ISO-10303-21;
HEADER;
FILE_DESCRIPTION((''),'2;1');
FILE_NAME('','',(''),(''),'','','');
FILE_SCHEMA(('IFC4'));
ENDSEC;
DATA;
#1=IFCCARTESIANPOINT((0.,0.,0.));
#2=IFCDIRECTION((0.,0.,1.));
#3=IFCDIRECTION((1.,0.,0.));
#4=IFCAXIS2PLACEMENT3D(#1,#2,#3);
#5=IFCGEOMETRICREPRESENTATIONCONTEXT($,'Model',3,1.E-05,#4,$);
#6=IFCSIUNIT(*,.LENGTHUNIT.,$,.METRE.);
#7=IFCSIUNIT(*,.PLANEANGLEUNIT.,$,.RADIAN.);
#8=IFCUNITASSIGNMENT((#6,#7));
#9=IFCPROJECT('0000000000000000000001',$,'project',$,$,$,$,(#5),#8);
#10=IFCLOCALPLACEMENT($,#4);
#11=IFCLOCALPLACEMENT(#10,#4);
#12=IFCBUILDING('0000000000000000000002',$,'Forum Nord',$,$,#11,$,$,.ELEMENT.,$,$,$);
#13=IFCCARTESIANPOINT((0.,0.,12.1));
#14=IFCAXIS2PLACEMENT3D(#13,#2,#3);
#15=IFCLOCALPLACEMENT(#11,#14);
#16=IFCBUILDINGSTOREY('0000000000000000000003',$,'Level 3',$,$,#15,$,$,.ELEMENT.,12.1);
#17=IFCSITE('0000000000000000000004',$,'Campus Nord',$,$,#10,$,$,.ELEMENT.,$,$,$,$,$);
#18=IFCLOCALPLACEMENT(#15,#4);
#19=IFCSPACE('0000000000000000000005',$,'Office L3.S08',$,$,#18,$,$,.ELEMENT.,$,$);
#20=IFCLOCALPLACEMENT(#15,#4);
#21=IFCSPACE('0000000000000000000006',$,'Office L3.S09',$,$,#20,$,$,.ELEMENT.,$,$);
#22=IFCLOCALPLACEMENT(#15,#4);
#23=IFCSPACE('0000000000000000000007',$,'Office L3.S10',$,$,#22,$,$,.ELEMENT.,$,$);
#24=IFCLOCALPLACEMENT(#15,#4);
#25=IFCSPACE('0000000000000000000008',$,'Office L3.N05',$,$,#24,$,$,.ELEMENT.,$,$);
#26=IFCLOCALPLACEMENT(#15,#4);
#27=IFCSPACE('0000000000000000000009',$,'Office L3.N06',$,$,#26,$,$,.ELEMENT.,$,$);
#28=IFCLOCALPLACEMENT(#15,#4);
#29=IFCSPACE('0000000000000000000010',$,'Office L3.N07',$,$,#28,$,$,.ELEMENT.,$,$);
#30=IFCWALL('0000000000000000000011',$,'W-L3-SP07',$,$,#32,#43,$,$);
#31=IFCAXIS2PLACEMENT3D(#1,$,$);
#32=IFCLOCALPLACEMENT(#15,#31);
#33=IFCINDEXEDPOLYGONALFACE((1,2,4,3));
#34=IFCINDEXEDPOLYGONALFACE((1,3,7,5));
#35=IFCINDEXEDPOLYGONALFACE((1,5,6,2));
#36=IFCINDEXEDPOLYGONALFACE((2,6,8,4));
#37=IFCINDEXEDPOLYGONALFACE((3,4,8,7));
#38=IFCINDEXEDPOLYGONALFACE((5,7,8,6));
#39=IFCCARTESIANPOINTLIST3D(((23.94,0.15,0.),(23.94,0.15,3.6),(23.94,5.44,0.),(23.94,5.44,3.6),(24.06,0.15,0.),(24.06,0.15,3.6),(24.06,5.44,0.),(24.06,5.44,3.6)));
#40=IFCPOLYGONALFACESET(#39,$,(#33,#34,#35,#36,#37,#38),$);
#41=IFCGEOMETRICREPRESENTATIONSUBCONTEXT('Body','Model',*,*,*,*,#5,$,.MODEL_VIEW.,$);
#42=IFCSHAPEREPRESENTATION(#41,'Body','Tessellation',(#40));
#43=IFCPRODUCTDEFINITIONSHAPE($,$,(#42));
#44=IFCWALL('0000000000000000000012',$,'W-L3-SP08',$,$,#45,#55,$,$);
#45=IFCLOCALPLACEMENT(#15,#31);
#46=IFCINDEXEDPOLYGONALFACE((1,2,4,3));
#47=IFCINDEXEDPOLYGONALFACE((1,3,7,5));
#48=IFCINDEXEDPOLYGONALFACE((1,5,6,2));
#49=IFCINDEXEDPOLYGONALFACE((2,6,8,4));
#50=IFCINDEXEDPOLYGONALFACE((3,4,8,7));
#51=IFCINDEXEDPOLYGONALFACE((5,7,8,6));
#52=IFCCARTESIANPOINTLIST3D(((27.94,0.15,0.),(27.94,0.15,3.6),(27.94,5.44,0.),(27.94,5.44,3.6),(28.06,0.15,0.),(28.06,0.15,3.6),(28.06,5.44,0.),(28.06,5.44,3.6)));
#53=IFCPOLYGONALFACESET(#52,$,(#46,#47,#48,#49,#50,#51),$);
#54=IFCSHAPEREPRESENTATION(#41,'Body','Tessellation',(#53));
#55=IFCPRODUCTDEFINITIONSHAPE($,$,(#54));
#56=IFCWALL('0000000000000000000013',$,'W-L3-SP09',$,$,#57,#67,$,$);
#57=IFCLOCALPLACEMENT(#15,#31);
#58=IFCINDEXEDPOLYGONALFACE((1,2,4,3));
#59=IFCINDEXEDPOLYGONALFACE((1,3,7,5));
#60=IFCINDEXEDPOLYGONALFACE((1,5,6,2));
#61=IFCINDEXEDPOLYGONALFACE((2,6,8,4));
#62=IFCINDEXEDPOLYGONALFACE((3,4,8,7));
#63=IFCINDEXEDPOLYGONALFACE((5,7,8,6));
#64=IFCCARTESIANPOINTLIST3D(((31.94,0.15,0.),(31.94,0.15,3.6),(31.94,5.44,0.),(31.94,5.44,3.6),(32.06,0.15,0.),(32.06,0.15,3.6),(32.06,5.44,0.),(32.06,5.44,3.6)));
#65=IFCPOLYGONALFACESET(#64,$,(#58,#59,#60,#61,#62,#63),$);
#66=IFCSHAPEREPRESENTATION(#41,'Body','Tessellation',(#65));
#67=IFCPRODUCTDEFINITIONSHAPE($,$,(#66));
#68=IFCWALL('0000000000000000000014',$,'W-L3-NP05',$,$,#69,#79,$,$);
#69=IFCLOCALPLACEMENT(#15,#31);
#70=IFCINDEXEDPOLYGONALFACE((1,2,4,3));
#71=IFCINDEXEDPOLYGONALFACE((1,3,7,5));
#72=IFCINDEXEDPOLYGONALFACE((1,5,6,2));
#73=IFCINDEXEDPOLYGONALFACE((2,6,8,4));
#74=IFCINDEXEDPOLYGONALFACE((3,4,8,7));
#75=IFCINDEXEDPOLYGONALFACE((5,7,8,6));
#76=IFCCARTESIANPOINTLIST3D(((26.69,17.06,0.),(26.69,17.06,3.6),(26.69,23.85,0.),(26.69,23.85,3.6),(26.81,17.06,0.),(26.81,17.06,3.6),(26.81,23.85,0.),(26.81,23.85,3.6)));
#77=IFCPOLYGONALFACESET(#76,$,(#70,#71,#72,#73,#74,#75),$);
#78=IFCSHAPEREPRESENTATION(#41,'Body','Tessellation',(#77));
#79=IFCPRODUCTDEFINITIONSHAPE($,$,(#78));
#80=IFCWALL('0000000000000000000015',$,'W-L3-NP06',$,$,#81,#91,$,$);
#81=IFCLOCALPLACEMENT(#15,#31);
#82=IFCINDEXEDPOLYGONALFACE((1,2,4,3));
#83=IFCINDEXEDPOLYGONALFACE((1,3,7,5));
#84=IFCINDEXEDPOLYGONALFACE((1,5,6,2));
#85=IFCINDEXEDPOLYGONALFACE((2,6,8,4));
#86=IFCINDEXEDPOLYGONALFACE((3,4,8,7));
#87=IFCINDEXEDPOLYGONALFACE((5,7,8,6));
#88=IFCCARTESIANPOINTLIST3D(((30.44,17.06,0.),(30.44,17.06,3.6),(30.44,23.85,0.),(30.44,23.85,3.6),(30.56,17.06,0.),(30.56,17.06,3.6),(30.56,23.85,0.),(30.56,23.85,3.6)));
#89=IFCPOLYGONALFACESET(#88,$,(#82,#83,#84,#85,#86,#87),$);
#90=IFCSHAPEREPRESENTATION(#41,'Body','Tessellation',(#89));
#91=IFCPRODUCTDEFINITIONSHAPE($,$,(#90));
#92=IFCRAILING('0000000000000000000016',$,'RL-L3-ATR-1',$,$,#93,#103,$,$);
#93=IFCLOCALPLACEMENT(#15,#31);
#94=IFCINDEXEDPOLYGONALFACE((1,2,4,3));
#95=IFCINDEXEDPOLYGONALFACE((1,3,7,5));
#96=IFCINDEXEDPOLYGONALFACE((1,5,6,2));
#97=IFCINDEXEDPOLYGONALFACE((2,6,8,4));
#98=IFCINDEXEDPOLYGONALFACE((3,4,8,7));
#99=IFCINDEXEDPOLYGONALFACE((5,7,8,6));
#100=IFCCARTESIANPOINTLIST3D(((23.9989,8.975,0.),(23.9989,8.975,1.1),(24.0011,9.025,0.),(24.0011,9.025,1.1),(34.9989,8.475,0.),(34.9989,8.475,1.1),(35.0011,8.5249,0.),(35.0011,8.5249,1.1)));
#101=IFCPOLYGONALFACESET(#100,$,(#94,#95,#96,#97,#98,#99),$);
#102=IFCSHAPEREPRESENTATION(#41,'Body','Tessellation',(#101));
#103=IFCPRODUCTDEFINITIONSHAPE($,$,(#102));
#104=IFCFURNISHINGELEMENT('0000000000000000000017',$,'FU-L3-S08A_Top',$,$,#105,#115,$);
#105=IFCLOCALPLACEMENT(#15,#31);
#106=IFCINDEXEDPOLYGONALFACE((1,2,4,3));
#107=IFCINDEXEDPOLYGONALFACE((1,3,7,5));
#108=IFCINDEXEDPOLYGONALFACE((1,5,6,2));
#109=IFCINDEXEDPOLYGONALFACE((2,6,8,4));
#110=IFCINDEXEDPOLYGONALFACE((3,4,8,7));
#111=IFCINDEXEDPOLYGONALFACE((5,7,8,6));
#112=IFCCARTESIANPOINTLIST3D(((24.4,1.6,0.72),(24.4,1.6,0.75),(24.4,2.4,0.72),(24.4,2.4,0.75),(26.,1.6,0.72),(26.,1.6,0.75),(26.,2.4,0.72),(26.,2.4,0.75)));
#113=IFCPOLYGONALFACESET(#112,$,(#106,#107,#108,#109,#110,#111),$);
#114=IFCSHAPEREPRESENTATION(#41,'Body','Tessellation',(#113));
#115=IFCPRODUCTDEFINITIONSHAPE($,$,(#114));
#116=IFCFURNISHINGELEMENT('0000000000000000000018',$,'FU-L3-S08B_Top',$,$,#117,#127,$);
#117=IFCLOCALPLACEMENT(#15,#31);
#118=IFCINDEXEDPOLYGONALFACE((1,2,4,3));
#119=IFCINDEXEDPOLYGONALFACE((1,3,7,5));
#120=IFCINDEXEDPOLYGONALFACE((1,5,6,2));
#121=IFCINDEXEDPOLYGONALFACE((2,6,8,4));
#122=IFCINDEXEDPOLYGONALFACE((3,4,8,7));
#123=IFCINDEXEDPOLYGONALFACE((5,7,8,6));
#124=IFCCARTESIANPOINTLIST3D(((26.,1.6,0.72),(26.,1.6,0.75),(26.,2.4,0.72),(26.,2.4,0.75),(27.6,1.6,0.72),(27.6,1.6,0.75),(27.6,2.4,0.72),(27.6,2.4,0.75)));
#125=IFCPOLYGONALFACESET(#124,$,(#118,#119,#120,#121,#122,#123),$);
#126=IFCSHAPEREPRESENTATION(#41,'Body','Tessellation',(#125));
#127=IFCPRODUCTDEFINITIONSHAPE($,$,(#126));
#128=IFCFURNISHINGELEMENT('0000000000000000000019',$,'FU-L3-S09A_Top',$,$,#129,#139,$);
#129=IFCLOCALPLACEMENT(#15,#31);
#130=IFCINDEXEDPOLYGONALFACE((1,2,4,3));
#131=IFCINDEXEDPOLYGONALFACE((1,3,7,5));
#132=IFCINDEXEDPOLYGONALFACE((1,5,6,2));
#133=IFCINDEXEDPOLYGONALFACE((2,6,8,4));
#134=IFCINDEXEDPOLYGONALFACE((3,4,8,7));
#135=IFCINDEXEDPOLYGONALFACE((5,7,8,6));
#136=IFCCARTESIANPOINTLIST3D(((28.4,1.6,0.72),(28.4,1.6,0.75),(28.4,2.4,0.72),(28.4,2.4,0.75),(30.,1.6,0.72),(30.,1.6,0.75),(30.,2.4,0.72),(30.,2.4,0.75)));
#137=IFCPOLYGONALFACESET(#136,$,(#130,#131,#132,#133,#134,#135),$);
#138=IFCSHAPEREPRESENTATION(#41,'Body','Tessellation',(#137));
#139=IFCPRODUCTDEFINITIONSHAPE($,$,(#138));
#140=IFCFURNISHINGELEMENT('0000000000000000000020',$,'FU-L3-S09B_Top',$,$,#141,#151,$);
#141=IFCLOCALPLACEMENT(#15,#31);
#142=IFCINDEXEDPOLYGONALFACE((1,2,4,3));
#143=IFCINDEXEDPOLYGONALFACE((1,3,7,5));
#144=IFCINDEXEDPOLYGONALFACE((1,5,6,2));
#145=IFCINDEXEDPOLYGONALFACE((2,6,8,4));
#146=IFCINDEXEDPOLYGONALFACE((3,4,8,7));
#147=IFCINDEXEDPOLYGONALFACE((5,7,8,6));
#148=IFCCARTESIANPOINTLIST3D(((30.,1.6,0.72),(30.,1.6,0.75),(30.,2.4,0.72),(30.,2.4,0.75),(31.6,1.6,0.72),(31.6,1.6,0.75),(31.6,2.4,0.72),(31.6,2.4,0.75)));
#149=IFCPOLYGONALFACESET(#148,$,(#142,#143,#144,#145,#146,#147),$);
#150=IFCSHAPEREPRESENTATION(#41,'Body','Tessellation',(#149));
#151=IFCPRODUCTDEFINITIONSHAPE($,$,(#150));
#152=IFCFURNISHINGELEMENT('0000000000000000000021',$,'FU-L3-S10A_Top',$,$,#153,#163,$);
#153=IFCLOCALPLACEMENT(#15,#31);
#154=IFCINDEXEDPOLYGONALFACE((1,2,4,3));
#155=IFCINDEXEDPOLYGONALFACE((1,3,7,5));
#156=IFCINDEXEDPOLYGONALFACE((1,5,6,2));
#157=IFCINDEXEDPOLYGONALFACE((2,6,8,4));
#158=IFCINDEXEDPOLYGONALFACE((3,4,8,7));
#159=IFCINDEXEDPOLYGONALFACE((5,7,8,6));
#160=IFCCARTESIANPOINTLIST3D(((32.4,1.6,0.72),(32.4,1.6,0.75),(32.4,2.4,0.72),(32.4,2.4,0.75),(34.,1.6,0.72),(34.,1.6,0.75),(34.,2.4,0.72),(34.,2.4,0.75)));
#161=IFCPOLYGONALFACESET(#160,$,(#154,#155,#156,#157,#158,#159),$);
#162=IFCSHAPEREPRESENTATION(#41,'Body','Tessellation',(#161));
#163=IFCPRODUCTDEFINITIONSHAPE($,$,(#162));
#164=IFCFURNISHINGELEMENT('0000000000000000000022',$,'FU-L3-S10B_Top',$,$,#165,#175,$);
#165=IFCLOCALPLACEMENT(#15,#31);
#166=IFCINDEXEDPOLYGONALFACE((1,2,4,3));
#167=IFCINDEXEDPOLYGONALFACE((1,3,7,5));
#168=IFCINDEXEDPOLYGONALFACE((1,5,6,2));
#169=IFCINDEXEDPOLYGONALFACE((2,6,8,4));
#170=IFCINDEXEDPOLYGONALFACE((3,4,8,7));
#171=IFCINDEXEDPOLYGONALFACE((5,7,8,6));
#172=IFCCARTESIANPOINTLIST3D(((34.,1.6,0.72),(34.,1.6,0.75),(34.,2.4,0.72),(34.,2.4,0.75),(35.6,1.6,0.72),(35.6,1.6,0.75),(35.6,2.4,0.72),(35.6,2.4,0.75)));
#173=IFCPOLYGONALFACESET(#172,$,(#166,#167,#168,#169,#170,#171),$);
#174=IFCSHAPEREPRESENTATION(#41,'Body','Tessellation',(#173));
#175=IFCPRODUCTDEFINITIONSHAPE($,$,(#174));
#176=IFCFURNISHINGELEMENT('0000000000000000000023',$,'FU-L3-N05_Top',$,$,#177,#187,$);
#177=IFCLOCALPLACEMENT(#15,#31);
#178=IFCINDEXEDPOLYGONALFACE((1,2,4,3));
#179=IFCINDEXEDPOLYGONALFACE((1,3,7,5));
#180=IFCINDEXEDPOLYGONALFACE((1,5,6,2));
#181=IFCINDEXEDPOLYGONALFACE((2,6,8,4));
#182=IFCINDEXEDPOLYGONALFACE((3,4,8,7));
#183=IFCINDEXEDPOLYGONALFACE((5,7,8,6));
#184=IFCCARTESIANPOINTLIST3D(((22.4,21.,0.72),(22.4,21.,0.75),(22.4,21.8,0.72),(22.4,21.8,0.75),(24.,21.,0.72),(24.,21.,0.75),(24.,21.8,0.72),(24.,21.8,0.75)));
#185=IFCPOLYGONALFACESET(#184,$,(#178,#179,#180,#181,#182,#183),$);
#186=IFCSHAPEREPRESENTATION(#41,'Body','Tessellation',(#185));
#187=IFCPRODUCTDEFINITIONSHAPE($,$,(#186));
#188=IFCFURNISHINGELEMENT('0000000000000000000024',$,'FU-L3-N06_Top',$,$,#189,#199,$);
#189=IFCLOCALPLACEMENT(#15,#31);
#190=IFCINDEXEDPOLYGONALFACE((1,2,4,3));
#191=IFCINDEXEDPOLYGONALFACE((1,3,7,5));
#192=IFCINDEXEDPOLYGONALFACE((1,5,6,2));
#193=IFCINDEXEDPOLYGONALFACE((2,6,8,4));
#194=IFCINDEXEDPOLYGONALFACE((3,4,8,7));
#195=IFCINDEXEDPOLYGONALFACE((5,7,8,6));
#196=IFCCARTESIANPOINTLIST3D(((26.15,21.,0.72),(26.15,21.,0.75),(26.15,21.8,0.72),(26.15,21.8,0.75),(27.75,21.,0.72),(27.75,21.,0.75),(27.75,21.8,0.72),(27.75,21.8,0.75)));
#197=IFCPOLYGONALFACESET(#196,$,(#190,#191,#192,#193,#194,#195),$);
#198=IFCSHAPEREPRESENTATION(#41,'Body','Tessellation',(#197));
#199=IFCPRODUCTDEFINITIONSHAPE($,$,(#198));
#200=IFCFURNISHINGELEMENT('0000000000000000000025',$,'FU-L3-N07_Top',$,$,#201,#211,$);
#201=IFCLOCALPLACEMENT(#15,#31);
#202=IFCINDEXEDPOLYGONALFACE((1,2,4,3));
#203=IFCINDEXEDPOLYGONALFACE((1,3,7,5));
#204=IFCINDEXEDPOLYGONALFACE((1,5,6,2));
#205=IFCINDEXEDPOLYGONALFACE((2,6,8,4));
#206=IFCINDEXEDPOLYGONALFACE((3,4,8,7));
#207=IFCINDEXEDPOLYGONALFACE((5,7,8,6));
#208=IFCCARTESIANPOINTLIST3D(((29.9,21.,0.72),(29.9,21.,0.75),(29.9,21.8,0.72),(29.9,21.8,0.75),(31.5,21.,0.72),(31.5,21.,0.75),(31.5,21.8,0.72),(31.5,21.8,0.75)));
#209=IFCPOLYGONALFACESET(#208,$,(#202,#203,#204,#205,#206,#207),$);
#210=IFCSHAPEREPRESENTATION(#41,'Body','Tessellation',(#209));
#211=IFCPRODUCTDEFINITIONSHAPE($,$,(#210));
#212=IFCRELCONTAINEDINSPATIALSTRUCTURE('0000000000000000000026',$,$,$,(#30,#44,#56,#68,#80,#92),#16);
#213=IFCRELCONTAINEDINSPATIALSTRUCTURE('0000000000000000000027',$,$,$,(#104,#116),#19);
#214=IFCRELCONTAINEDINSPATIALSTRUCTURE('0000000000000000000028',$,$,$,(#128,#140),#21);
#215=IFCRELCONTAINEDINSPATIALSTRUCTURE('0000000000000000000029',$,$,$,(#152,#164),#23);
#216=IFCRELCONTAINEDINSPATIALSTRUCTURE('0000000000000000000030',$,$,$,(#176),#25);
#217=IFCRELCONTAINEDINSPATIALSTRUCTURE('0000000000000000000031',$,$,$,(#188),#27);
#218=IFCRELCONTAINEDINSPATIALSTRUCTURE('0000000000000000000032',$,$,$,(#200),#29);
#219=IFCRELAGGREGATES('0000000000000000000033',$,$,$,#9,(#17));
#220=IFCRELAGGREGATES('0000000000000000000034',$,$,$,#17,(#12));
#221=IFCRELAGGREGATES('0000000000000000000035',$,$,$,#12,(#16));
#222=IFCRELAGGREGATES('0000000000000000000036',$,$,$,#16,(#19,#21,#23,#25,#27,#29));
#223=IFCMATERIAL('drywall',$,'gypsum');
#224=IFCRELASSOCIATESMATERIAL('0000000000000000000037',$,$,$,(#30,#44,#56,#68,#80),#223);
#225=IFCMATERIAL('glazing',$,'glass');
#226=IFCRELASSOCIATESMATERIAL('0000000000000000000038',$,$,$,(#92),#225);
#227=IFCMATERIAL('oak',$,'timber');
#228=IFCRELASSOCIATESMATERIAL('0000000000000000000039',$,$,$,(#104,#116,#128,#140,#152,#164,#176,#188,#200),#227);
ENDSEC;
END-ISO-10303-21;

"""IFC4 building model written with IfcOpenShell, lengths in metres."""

from ifc_helpers import new_model, si_unit, frame, frame_2d, origin_with_axes, place, context, subcontext, project, spatial, polyline, rectangle, outline, extrude, material, element, save


model = new_model("IFC4")

# Units and contexts
model_context = context("Model", 3, precision=1e-05, world=origin_with_axes())
body_context = subcontext(model_context, "Body", "Model", "MODEL_VIEW")
ifc_project = project(units=[si_unit("LENGTHUNIT", "METRE"), si_unit("PLANEANGLEUNIT", "RADIAN")], contexts=[model_context])

# Site, building, storey
site_placement = place(None, origin_with_axes())
site = spatial("IfcSite", under=ifc_project, at=site_placement, Name="Campus Nord", CompositionType="ELEMENT")
building_placement = place(site_placement, origin_with_axes())
building = spatial("IfcBuilding", under=site, at=building_placement, Name="Forum Nord", CompositionType="ELEMENT")
storey_placement = place(building_placement, frame((0.0, 0.0, 12.1), z_axis=(0.0, 0.0, 1.0), x_axis=(1.0, 0.0, 0.0)))
storey = spatial("IfcBuildingStorey", under=building, at=storey_placement, Name="Level 3", CompositionType="ELEMENT", Elevation=12.1)

# Walls
ifc_material_1 = material(Name="drywall", Category="gypsum")
for number, where, z_axis, x_axis, name in (
    (1, (24.0, 0.0, 0.0), (0.0, 0.0, 1.0), (0.0, 1.0, 0.0), "W-L3-SP07"),
    (2, (28.0, 0.0, 0.0), (0.0, 0.0, 1.0), (0.0, 1.0, 0.0), "W-L3-SP08"),
    (3, (32.0, 0.0, 0.0), (0.0, 0.0, 1.0), (0.0, 1.0, 0.0), "W-L3-SP09"),
):
    element("IfcWall", number, at=place(storey_placement, frame(where, z_axis=z_axis, x_axis=x_axis)), inside=storey, material=ifc_material_1, Name=name, context=body_context, shape_type="SweptSolid", body=[
        extrude(outline(polyline([(0.15, -0.06), (5.44, -0.06), (5.44, 0.06), (0.15, 0.06), (0.15, -0.06)])), origin_with_axes(), (0.0, 0.0, 1.0), 3.6),
    ])
for number, where, z_axis, x_axis, name in (
    (4, (26.75, 17.0, 0.0), (0.0, 0.0, 1.0), (0.0, 1.0, 0.0), "W-L3-NP05"),
    (5, (30.5, 17.0, 0.0), (0.0, 0.0, 1.0), (0.0, 1.0, 0.0), "W-L3-NP06"),
):
    element("IfcWall", number, at=place(storey_placement, frame(where, z_axis=z_axis, x_axis=x_axis)), inside=storey, material=ifc_material_1, Name=name, context=body_context, shape_type="SweptSolid", body=[
        extrude(outline(polyline([(0.06, -0.06), (6.85, -0.06), (6.85, 0.06), (0.06, 0.06), (0.06, -0.06)])), origin_with_axes(), (0.0, 0.0, 1.0), 3.6),
    ])

# Railing
ifc_material_2 = material(Name="glazing", Category="glass")
railing_placement = place(storey_placement, frame((24.0, 9.0, 0.0), z_axis=(0.0, 0.0, 1.0), x_axis=(0.99897, -0.04541, 0.0)))
element("IfcRailing", 6, at=railing_placement, inside=storey, material=ifc_material_2, Name="RL-L3-ATR-1", context=body_context, shape_type="SweptSolid", body=[
    extrude(rectangle(XDim=11.0114, YDim=0.05, at=frame_2d((5.5057, 0.0), x_axis=(1.0, 0.0))), origin_with_axes(), (0.0, 0.0, 1.0), 1.1),
])

# Shared definitions
space_1_placement = place(storey_placement, origin_with_axes())
space_1 = spatial("IfcSpace", under=storey, at=space_1_placement, Name="Office L3.S08", CompositionType="ELEMENT")

# Furnishing elements
ifc_material_3 = material(Name="oak", Category="timber")
furnishing_1_placement = place(storey_placement, frame((24.4, 1.0, 0.0), z_axis=(0.0, 0.0, 1.0), x_axis=(1.0, 0.0, 0.0)))
element("IfcFurnishingElement", 7, at=furnishing_1_placement, inside=space_1, material=ifc_material_3, Name="FU-L3-S08A_Top", context=body_context, shape_type="SweptSolid", body=[
    extrude(rectangle(XDim=1.6, YDim=0.8, at=frame_2d((0.8, 1.0), x_axis=(1.0, 0.0))), frame((0.0, 0.0, 0.72), z_axis=(0.0, 0.0, 1.0), x_axis=(1.0, 0.0, 0.0)), (0.0, 0.0, 1.0), 0.03),
])
furnishing_2_placement = place(storey_placement, frame((26.0, 1.0, 0.0), z_axis=(0.0, 0.0, 1.0), x_axis=(1.0, 0.0, 0.0)))
element("IfcFurnishingElement", 8, at=furnishing_2_placement, inside=space_1, material=ifc_material_3, Name="FU-L3-S08B_Top", context=body_context, shape_type="SweptSolid", body=[
    extrude(rectangle(XDim=1.6, YDim=0.8, at=frame_2d((0.8, 1.0), x_axis=(1.0, 0.0))), frame((0.0, 0.0, 0.72), z_axis=(0.0, 0.0, 1.0), x_axis=(1.0, 0.0, 0.0)), (0.0, 0.0, 1.0), 0.03),
])

# Shared definitions
space_2_placement = place(storey_placement, origin_with_axes())
space_2 = spatial("IfcSpace", under=storey, at=space_2_placement, Name="Office L3.S09", CompositionType="ELEMENT")

# Furnishing elements
furnishing_3_placement = place(storey_placement, frame((28.4, 1.0, 0.0), z_axis=(0.0, 0.0, 1.0), x_axis=(1.0, 0.0, 0.0)))
element("IfcFurnishingElement", 9, at=furnishing_3_placement, inside=space_2, material=ifc_material_3, Name="FU-L3-S09A_Top", context=body_context, shape_type="SweptSolid", body=[
    extrude(rectangle(XDim=1.6, YDim=0.8, at=frame_2d((0.8, 1.0), x_axis=(1.0, 0.0))), frame((0.0, 0.0, 0.72), z_axis=(0.0, 0.0, 1.0), x_axis=(1.0, 0.0, 0.0)), (0.0, 0.0, 1.0), 0.03),
])
furnishing_4_placement = place(storey_placement, frame((30.0, 1.0, 0.0), z_axis=(0.0, 0.0, 1.0), x_axis=(1.0, 0.0, 0.0)))
element("IfcFurnishingElement", 10, at=furnishing_4_placement, inside=space_2, material=ifc_material_3, Name="FU-L3-S09B_Top", context=body_context, shape_type="SweptSolid", body=[
    extrude(rectangle(XDim=1.6, YDim=0.8, at=frame_2d((0.8, 1.0), x_axis=(1.0, 0.0))), frame((0.0, 0.0, 0.72), z_axis=(0.0, 0.0, 1.0), x_axis=(1.0, 0.0, 0.0)), (0.0, 0.0, 1.0), 0.03),
])

# Shared definitions
space_3_placement = place(storey_placement, origin_with_axes())
space_3 = spatial("IfcSpace", under=storey, at=space_3_placement, Name="Office L3.S10", CompositionType="ELEMENT")

# Furnishing elements
furnishing_5_placement = place(storey_placement, frame((32.4, 1.0, 0.0), z_axis=(0.0, 0.0, 1.0), x_axis=(1.0, 0.0, 0.0)))
element("IfcFurnishingElement", 11, at=furnishing_5_placement, inside=space_3, material=ifc_material_3, Name="FU-L3-S10A_Top", context=body_context, shape_type="SweptSolid", body=[
    extrude(rectangle(XDim=1.6, YDim=0.8, at=frame_2d((0.8, 1.0), x_axis=(1.0, 0.0))), frame((0.0, 0.0, 0.72), z_axis=(0.0, 0.0, 1.0), x_axis=(1.0, 0.0, 0.0)), (0.0, 0.0, 1.0), 0.03),
])
furnishing_6_placement = place(storey_placement, frame((34.0, 1.0, 0.0), z_axis=(0.0, 0.0, 1.0), x_axis=(1.0, 0.0, 0.0)))
element("IfcFurnishingElement", 12, at=furnishing_6_placement, inside=space_3, material=ifc_material_3, Name="FU-L3-S10B_Top", context=body_context, shape_type="SweptSolid", body=[
    extrude(rectangle(XDim=1.6, YDim=0.8, at=frame_2d((0.8, 1.0), x_axis=(1.0, 0.0))), frame((0.0, 0.0, 0.72), z_axis=(0.0, 0.0, 1.0), x_axis=(1.0, 0.0, 0.0)), (0.0, 0.0, 1.0), 0.03),
])

# Shared definitions
space_4_placement = place(storey_placement, origin_with_axes())
space_4 = spatial("IfcSpace", under=storey, at=space_4_placement, Name="Office L3.N05", CompositionType="ELEMENT")

# Furnishing element
furnishing_7_placement = place(storey_placement, frame((24.0, 22.4, 0.0), z_axis=(0.0, 0.0, 1.0), x_axis=(-1.0, 0.0, 0.0)))
element("IfcFurnishingElement", 13, at=furnishing_7_placement, inside=space_4, material=ifc_material_3, Name="FU-L3-N05_Top", context=body_context, shape_type="SweptSolid", body=[
    extrude(rectangle(XDim=1.6, YDim=0.8, at=frame_2d((0.8, 1.0), x_axis=(1.0, 0.0))), frame((0.0, 0.0, 0.72), z_axis=(0.0, 0.0, 1.0), x_axis=(1.0, 0.0, 0.0)), (0.0, 0.0, 1.0), 0.03),
])

# Shared definitions
space_5_placement = place(storey_placement, origin_with_axes())
space_5 = spatial("IfcSpace", under=storey, at=space_5_placement, Name="Office L3.N06", CompositionType="ELEMENT")

# Furnishing element
furnishing_8_placement = place(storey_placement, frame((27.75, 22.4, 0.0), z_axis=(0.0, 0.0, 1.0), x_axis=(-1.0, 0.0, 0.0)))
element("IfcFurnishingElement", 14, at=furnishing_8_placement, inside=space_5, material=ifc_material_3, Name="FU-L3-N06_Top", context=body_context, shape_type="SweptSolid", body=[
    extrude(rectangle(XDim=1.6, YDim=0.8, at=frame_2d((0.8, 1.0), x_axis=(1.0, 0.0))), frame((0.0, 0.0, 0.72), z_axis=(0.0, 0.0, 1.0), x_axis=(1.0, 0.0, 0.0)), (0.0, 0.0, 1.0), 0.03),
])

# Shared definitions
space_6_placement = place(storey_placement, origin_with_axes())
space_6 = spatial("IfcSpace", under=storey, at=space_6_placement, Name="Office L3.N07", CompositionType="ELEMENT")

# Furnishing element
furnishing_9_placement = place(storey_placement, frame((31.5, 22.4, 0.0), z_axis=(0.0, 0.0, 1.0), x_axis=(-1.0, 0.0, 0.0)))
element("IfcFurnishingElement", 15, at=furnishing_9_placement, inside=space_6, material=ifc_material_3, Name="FU-L3-N07_Top", context=body_context, shape_type="SweptSolid", body=[
    extrude(rectangle(XDim=1.6, YDim=0.8, at=frame_2d((0.8, 1.0), x_axis=(1.0, 0.0))), frame((0.0, 0.0, 0.72), z_axis=(0.0, 0.0, 1.0), x_axis=(1.0, 0.0, 0.0)), (0.0, 0.0, 1.0), 0.03),
])

save(model, "model.ifc")
